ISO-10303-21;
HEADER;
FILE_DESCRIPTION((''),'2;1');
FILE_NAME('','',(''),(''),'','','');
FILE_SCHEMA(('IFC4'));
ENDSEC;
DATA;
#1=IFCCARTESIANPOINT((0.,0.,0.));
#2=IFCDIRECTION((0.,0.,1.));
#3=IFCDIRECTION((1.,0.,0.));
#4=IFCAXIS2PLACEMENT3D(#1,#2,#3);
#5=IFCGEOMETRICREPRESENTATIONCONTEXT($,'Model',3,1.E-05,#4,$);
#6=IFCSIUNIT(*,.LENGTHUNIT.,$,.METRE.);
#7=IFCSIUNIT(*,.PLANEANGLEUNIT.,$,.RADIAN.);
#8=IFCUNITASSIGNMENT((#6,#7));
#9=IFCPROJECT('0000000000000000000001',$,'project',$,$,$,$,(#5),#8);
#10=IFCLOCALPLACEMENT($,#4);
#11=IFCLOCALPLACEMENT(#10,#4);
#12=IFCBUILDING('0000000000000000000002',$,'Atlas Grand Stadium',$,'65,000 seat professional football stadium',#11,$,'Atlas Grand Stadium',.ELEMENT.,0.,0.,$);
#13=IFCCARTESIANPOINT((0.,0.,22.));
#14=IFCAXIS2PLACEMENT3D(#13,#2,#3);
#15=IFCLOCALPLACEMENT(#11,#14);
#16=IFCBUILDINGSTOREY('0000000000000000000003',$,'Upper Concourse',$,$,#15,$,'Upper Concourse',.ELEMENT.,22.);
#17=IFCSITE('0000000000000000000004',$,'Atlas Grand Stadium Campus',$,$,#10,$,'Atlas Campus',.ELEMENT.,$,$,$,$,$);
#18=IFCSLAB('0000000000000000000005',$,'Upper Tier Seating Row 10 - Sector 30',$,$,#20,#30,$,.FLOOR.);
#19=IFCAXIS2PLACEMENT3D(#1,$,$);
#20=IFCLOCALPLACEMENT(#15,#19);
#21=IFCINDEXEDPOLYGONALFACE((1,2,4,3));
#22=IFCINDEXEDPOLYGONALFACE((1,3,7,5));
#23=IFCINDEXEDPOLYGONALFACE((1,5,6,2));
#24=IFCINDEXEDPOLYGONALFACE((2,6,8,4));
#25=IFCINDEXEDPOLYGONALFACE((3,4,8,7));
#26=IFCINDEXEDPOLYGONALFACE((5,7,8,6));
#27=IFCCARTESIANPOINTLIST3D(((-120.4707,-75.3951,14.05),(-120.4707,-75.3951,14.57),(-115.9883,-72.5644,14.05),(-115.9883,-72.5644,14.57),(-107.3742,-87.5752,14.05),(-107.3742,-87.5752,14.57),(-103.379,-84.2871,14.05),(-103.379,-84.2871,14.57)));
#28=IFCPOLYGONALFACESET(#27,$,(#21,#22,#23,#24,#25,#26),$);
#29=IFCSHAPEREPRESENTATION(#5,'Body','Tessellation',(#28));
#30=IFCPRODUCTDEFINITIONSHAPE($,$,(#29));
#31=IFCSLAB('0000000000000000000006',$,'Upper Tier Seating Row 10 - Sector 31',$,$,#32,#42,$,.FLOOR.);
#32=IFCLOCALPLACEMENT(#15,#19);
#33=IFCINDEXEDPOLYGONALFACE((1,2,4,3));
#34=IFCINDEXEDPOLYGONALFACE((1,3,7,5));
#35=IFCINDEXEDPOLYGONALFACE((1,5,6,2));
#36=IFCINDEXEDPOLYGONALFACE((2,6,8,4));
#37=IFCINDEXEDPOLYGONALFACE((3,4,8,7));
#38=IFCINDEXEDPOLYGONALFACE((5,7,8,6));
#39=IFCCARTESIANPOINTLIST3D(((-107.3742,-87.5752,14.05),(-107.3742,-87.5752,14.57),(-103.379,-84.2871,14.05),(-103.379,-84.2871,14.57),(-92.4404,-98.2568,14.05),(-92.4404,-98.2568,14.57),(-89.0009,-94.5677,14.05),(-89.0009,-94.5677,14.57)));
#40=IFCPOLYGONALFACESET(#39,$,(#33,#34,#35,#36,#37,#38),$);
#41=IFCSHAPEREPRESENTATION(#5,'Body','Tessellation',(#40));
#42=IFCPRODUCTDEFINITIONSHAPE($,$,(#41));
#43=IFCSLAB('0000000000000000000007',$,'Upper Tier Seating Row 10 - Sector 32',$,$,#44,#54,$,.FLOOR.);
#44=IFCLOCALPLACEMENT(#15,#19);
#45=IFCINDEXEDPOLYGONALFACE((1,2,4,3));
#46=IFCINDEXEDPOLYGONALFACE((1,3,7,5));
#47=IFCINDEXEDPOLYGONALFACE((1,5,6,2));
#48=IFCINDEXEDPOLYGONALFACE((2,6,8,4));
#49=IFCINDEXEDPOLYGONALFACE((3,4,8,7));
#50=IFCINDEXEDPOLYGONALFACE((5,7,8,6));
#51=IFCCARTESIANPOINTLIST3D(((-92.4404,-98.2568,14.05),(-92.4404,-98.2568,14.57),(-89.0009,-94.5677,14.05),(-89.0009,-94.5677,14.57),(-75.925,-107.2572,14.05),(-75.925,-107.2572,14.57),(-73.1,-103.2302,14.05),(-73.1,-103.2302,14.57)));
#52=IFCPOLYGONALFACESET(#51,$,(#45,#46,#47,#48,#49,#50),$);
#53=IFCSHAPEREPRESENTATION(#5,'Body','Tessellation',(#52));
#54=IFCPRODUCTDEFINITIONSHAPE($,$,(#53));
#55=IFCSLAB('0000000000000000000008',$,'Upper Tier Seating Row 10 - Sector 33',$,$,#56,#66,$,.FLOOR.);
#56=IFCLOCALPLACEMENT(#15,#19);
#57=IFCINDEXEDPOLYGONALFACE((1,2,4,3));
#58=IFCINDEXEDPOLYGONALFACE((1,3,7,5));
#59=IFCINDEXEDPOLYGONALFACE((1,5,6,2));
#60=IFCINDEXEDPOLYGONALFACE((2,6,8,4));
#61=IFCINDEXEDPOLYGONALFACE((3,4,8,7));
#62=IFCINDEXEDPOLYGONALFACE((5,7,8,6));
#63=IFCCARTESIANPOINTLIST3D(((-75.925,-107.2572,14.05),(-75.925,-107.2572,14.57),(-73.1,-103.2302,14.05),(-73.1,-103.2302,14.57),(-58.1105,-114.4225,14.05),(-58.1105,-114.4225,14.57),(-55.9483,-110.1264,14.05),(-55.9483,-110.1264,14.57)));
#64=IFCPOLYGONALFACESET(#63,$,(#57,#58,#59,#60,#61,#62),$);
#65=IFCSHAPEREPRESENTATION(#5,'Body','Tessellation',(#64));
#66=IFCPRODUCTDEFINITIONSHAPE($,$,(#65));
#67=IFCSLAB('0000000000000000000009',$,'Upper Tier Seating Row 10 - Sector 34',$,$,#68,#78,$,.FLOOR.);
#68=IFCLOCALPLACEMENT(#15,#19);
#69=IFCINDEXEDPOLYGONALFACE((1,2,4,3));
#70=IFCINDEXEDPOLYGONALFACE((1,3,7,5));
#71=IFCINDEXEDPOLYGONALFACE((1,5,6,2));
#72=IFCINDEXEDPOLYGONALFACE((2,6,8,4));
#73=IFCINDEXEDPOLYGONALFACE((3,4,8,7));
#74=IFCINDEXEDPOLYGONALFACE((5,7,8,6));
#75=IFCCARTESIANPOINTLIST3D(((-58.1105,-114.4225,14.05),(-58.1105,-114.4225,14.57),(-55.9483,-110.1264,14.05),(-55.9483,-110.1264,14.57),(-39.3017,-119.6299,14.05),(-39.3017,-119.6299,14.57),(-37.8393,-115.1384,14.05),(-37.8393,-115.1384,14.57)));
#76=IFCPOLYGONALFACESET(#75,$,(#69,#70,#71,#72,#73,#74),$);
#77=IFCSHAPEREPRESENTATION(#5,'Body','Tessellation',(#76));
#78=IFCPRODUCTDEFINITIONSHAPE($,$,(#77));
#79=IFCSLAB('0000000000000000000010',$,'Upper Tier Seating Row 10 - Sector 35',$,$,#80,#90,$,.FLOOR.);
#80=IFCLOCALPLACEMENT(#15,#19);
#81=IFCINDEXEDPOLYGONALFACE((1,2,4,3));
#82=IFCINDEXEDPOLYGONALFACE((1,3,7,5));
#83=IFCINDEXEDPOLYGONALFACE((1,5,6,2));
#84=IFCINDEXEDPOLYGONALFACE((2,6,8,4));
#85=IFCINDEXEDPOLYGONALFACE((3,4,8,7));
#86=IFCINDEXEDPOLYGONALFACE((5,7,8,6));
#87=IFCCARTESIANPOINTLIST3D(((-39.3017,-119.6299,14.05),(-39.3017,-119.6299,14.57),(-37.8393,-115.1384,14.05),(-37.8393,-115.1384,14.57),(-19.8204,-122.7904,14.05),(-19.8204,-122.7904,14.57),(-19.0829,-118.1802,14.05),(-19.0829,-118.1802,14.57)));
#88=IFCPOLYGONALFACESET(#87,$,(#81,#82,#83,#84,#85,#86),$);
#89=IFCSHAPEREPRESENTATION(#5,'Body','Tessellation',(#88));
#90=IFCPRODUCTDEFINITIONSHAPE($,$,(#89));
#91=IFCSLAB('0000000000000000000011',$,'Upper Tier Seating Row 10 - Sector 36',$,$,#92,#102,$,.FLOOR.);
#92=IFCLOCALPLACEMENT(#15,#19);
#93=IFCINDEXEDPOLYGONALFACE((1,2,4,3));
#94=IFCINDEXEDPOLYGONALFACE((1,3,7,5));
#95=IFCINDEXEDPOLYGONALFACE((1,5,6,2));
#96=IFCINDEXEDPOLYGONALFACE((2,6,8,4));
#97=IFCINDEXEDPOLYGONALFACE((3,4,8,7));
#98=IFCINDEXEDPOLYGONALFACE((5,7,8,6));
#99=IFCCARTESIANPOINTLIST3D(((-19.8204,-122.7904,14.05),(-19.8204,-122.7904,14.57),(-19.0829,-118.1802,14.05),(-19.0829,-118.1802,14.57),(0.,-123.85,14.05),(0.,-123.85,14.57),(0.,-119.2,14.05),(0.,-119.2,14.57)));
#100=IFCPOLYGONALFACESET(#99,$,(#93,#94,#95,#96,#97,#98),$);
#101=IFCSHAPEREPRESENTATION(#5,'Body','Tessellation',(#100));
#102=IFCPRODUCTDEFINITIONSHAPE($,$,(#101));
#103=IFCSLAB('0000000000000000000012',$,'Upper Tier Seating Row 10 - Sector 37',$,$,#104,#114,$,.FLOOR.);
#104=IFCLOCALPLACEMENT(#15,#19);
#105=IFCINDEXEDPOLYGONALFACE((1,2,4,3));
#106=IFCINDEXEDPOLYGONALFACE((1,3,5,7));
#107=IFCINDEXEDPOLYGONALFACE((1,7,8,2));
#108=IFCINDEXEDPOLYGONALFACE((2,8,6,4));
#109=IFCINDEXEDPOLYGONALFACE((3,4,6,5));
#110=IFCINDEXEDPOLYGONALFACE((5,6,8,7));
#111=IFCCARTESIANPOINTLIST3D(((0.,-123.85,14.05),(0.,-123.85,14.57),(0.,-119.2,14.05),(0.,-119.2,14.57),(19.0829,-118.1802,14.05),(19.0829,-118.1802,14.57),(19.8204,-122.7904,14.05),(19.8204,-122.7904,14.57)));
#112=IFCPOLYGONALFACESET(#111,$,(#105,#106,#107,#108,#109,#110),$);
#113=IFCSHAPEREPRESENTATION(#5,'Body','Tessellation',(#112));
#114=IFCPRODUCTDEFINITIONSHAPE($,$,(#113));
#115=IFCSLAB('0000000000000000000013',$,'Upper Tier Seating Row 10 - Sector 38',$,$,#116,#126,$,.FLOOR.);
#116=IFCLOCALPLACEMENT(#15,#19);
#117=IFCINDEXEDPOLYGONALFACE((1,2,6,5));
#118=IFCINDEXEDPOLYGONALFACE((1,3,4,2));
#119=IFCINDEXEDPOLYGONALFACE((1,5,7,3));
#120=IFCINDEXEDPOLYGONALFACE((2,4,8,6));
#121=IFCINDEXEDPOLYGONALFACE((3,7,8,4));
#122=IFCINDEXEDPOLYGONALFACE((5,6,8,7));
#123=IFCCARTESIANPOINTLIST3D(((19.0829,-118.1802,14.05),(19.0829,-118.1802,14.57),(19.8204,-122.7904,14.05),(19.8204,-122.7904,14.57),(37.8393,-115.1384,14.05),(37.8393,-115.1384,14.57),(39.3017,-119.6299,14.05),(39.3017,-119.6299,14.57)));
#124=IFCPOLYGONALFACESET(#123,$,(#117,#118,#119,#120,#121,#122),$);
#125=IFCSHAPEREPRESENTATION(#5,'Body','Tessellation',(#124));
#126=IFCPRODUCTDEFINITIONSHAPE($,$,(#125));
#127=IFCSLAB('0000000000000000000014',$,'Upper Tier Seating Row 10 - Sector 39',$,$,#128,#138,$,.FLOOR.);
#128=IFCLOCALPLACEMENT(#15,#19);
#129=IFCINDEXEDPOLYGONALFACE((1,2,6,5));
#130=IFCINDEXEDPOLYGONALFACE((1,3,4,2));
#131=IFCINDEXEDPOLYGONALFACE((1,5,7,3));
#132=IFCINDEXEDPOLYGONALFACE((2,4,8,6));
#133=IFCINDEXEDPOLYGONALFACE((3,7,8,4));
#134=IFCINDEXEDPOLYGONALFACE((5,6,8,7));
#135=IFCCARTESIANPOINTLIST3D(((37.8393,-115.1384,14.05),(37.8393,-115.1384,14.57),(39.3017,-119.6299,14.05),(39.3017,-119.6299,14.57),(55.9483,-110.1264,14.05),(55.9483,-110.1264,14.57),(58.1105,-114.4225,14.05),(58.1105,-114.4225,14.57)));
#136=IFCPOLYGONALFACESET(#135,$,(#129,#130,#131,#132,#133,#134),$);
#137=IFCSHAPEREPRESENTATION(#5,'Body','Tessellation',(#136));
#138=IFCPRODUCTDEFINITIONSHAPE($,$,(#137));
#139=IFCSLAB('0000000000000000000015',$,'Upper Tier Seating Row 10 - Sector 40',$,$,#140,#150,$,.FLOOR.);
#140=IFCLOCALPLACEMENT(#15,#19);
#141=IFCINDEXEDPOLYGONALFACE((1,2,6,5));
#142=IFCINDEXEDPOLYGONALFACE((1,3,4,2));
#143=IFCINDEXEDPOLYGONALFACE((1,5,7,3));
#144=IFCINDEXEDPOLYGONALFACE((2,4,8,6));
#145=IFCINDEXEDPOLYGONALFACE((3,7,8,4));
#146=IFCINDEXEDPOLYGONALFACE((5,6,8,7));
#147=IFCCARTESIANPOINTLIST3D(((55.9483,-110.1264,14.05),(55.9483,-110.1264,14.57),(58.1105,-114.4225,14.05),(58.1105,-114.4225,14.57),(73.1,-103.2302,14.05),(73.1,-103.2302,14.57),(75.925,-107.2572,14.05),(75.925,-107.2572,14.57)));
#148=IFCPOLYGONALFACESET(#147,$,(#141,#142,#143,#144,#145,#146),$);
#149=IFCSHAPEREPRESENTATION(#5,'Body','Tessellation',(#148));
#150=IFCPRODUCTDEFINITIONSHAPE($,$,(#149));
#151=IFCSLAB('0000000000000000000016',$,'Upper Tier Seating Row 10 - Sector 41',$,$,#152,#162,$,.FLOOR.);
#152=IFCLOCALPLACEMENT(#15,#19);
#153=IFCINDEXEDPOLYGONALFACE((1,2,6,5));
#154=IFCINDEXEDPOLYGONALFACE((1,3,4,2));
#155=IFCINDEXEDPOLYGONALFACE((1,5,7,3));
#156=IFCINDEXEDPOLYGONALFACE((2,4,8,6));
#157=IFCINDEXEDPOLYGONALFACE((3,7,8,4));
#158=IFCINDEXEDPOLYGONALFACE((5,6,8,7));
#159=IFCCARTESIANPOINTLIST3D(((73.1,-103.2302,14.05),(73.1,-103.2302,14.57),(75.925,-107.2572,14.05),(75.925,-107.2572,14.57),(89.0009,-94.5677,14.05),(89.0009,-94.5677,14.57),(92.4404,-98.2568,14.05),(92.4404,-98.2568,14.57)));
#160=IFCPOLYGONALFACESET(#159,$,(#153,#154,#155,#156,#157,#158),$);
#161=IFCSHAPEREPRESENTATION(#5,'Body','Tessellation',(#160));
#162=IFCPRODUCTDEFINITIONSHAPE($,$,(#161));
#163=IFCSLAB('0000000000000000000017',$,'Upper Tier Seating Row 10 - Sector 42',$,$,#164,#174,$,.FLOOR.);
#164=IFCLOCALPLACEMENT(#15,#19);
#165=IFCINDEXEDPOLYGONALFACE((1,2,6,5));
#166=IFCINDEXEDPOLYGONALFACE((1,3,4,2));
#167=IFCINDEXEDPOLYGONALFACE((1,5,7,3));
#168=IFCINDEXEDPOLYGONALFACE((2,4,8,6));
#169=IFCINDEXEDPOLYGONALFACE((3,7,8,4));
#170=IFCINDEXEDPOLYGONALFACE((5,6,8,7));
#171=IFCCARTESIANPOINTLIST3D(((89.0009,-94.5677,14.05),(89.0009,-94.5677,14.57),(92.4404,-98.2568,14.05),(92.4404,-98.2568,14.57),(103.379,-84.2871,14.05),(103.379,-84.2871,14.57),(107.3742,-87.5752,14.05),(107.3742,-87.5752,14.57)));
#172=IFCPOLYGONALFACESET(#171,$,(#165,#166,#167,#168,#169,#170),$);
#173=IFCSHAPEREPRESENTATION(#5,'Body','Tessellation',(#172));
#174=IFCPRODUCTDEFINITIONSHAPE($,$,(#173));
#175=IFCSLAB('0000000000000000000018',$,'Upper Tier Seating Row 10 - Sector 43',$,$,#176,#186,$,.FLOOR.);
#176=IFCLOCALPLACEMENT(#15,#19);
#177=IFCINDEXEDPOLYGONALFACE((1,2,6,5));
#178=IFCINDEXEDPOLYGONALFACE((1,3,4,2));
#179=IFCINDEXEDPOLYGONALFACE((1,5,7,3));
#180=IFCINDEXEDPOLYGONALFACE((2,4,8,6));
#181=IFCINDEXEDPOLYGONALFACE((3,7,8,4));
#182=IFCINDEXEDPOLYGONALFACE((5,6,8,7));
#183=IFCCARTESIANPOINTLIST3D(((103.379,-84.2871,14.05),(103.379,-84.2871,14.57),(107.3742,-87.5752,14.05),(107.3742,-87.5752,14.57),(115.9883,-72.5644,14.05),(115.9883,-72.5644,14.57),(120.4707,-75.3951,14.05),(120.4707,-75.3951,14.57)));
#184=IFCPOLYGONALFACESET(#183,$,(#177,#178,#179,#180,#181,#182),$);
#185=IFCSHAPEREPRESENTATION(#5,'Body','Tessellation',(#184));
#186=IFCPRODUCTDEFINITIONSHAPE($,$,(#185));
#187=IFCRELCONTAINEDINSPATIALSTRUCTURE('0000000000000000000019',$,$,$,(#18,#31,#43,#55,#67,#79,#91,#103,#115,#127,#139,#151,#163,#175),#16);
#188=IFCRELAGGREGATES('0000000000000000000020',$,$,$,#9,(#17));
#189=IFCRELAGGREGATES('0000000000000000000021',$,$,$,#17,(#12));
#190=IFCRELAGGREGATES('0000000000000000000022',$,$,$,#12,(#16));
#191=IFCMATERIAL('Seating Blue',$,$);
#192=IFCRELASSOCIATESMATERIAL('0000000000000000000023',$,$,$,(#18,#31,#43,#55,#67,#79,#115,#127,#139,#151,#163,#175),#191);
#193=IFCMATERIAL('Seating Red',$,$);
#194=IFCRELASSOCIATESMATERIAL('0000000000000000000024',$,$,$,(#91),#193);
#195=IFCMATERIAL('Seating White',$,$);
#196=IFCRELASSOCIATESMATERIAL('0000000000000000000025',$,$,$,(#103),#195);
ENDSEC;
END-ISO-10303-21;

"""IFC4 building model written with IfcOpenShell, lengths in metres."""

from ifc_helpers import new_model, si_unit, frame, origin_with_axes, place, context, project, spatial, polyline, outline, extrude, material, element, save


model = new_model("IFC4")

# Units and contexts
model_context = context("Model", 3, precision=1e-05, world=origin_with_axes())
ifc_project = project(units=[si_unit("LENGTHUNIT", "METRE"), si_unit("PLANEANGLEUNIT", "RADIAN")], contexts=[model_context])

# Site, building, storey
site_placement = place(None, origin_with_axes())
site = spatial("IfcSite", under=ifc_project, at=site_placement, Name="Atlas Grand Stadium Campus", LongName="Atlas Campus", CompositionType="ELEMENT")
building_placement = place(site_placement, origin_with_axes())
building = spatial("IfcBuilding", under=site, at=building_placement, Name="Atlas Grand Stadium", ObjectType="65,000 seat professional football stadium", LongName="Atlas Grand Stadium", CompositionType="ELEMENT", ElevationOfRefHeight=0.0, ElevationOfTerrain=0.0)
storey_placement = place(building_placement, frame((0.0, 0.0, 22.0), z_axis=(0.0, 0.0, 1.0), x_axis=(1.0, 0.0, 0.0)))
storey = spatial("IfcBuildingStorey", under=building, at=storey_placement, Name="Upper Concourse", LongName="Upper Concourse", CompositionType="ELEMENT", Elevation=22.0)

# Slabs
ifc_material_1 = material(Name="Seating Blue")
slab_1_placement = place(storey_placement, frame((0.0, 0.0, 14.05), z_axis=(0.0, 0.0, 1.0), x_axis=(1.0, 0.0, 0.0)))
element("IfcSlab", 1, at=slab_1_placement, inside=storey, material=ifc_material_1, Name="Upper Tier Seating Row 10 - Sector 30", PredefinedType="FLOOR", context=model_context, shape_type="SweptSolid", body=[
    extrude(outline(polyline([(-120.4707, -75.3951), (-107.3742, -87.5752), (-103.379, -84.2871), (-115.9883, -72.5644), (-120.4707, -75.3951)])), origin_with_axes(), (0.0, 0.0, 1.0), 0.52),
])
slab_2_placement = place(storey_placement, frame((0.0, 0.0, 14.05), z_axis=(0.0, 0.0, 1.0), x_axis=(1.0, 0.0, 0.0)))
element("IfcSlab", 2, at=slab_2_placement, inside=storey, material=ifc_material_1, Name="Upper Tier Seating Row 10 - Sector 31", PredefinedType="FLOOR", context=model_context, shape_type="SweptSolid", body=[
    extrude(outline(polyline([(-107.3742, -87.5752), (-92.4404, -98.2568), (-89.0009, -94.5677), (-103.379, -84.2871), (-107.3742, -87.5752)])), origin_with_axes(), (0.0, 0.0, 1.0), 0.52),
])
slab_3_placement = place(storey_placement, frame((0.0, 0.0, 14.05), z_axis=(0.0, 0.0, 1.0), x_axis=(1.0, 0.0, 0.0)))
element("IfcSlab", 3, at=slab_3_placement, inside=storey, material=ifc_material_1, Name="Upper Tier Seating Row 10 - Sector 32", PredefinedType="FLOOR", context=model_context, shape_type="SweptSolid", body=[
    extrude(outline(polyline([(-92.4404, -98.2568), (-75.925, -107.2572), (-73.1, -103.2302), (-89.0009, -94.5677), (-92.4404, -98.2568)])), origin_with_axes(), (0.0, 0.0, 1.0), 0.52),
])
slab_4_placement = place(storey_placement, frame((0.0, 0.0, 14.05), z_axis=(0.0, 0.0, 1.0), x_axis=(1.0, 0.0, 0.0)))
element("IfcSlab", 4, at=slab_4_placement, inside=storey, material=ifc_material_1, Name="Upper Tier Seating Row 10 - Sector 33", PredefinedType="FLOOR", context=model_context, shape_type="SweptSolid", body=[
    extrude(outline(polyline([(-75.925, -107.2572), (-58.1105, -114.4225), (-55.9483, -110.1264), (-73.1, -103.2302), (-75.925, -107.2572)])), origin_with_axes(), (0.0, 0.0, 1.0), 0.52),
])
slab_5_placement = place(storey_placement, frame((0.0, 0.0, 14.05), z_axis=(0.0, 0.0, 1.0), x_axis=(1.0, 0.0, 0.0)))
element("IfcSlab", 5, at=slab_5_placement, inside=storey, material=ifc_material_1, Name="Upper Tier Seating Row 10 - Sector 34", PredefinedType="FLOOR", context=model_context, shape_type="SweptSolid", body=[
    extrude(outline(polyline([(-58.1105, -114.4225), (-39.3017, -119.6299), (-37.8393, -115.1384), (-55.9483, -110.1264), (-58.1105, -114.4225)])), origin_with_axes(), (0.0, 0.0, 1.0), 0.52),
])
slab_6_placement = place(storey_placement, frame((0.0, 0.0, 14.05), z_axis=(0.0, 0.0, 1.0), x_axis=(1.0, 0.0, 0.0)))
element("IfcSlab", 6, at=slab_6_placement, inside=storey, material=ifc_material_1, Name="Upper Tier Seating Row 10 - Sector 35", PredefinedType="FLOOR", context=model_context, shape_type="SweptSolid", body=[
    extrude(outline(polyline([(-39.3017, -119.6299), (-19.8204, -122.7905), (-19.0829, -118.1802), (-37.8393, -115.1384), (-39.3017, -119.6299)])), origin_with_axes(), (0.0, 0.0, 1.0), 0.52),
])
ifc_material_2 = material(Name="Seating Red")
slab_7_placement = place(storey_placement, frame((0.0, 0.0, 14.05), z_axis=(0.0, 0.0, 1.0), x_axis=(1.0, 0.0, 0.0)))
element("IfcSlab", 7, at=slab_7_placement, inside=storey, material=ifc_material_2, Name="Upper Tier Seating Row 10 - Sector 36", PredefinedType="FLOOR", context=model_context, shape_type="SweptSolid", body=[
    extrude(outline(polyline([(-19.8204, -122.7905), (0.0, -123.85), (0.0, -119.2), (-19.0829, -118.1802), (-19.8204, -122.7905)])), origin_with_axes(), (0.0, 0.0, 1.0), 0.52),
])
ifc_material_3 = material(Name="Seating White")
slab_8_placement = place(storey_placement, frame((0.0, 0.0, 14.05), z_axis=(0.0, 0.0, 1.0), x_axis=(1.0, 0.0, 0.0)))
element("IfcSlab", 8, at=slab_8_placement, inside=storey, material=ifc_material_3, Name="Upper Tier Seating Row 10 - Sector 37", PredefinedType="FLOOR", context=model_context, shape_type="SweptSolid", body=[
    extrude(outline(polyline([(0.0, -123.85), (19.8204, -122.7905), (19.0829, -118.1802), (0.0, -119.2), (0.0, -123.85)])), origin_with_axes(), (0.0, 0.0, 1.0), 0.52),
])
slab_9_placement = place(storey_placement, frame((0.0, 0.0, 14.05), z_axis=(0.0, 0.0, 1.0), x_axis=(1.0, 0.0, 0.0)))
element("IfcSlab", 9, at=slab_9_placement, inside=storey, material=ifc_material_1, Name="Upper Tier Seating Row 10 - Sector 38", PredefinedType="FLOOR", context=model_context, shape_type="SweptSolid", body=[
    extrude(outline(polyline([(19.8204, -122.7905), (39.3017, -119.6299), (37.8393, -115.1384), (19.0829, -118.1802), (19.8204, -122.7905)])), origin_with_axes(), (0.0, 0.0, 1.0), 0.52),
])
slab_10_placement = place(storey_placement, frame((0.0, 0.0, 14.05), z_axis=(0.0, 0.0, 1.0), x_axis=(1.0, 0.0, 0.0)))
element("IfcSlab", 10, at=slab_10_placement, inside=storey, material=ifc_material_1, Name="Upper Tier Seating Row 10 - Sector 39", PredefinedType="FLOOR", context=model_context, shape_type="SweptSolid", body=[
    extrude(outline(polyline([(39.3017, -119.6299), (58.1105, -114.4225), (55.9483, -110.1264), (37.8393, -115.1384), (39.3017, -119.6299)])), origin_with_axes(), (0.0, 0.0, 1.0), 0.52),
])
slab_11_placement = place(storey_placement, frame((0.0, 0.0, 14.05), z_axis=(0.0, 0.0, 1.0), x_axis=(1.0, 0.0, 0.0)))
element("IfcSlab", 11, at=slab_11_placement, inside=storey, material=ifc_material_1, Name="Upper Tier Seating Row 10 - Sector 40", PredefinedType="FLOOR", context=model_context, shape_type="SweptSolid", body=[
    extrude(outline(polyline([(58.1105, -114.4225), (75.925, -107.2572), (73.1, -103.2302), (55.9483, -110.1264), (58.1105, -114.4225)])), origin_with_axes(), (0.0, 0.0, 1.0), 0.52),
])
slab_12_placement = place(storey_placement, frame((0.0, 0.0, 14.05), z_axis=(0.0, 0.0, 1.0), x_axis=(1.0, 0.0, 0.0)))
element("IfcSlab", 12, at=slab_12_placement, inside=storey, material=ifc_material_1, Name="Upper Tier Seating Row 10 - Sector 41", PredefinedType="FLOOR", context=model_context, shape_type="SweptSolid", body=[
    extrude(outline(polyline([(75.925, -107.2572), (92.4404, -98.2568), (89.0009, -94.5677), (73.1, -103.2302), (75.925, -107.2572)])), origin_with_axes(), (0.0, 0.0, 1.0), 0.52),
])
slab_13_placement = place(storey_placement, frame((0.0, 0.0, 14.05), z_axis=(0.0, 0.0, 1.0), x_axis=(1.0, 0.0, 0.0)))
element("IfcSlab", 13, at=slab_13_placement, inside=storey, material=ifc_material_1, Name="Upper Tier Seating Row 10 - Sector 42", PredefinedType="FLOOR", context=model_context, shape_type="SweptSolid", body=[
    extrude(outline(polyline([(92.4404, -98.2568), (107.3742, -87.5752), (103.379, -84.2871), (89.0009, -94.5677), (92.4404, -98.2568)])), origin_with_axes(), (0.0, 0.0, 1.0), 0.52),
])
slab_14_placement = place(storey_placement, frame((0.0, 0.0, 14.05), z_axis=(0.0, 0.0, 1.0), x_axis=(1.0, 0.0, 0.0)))
element("IfcSlab", 14, at=slab_14_placement, inside=storey, material=ifc_material_1, Name="Upper Tier Seating Row 10 - Sector 43", PredefinedType="FLOOR", context=model_context, shape_type="SweptSolid", body=[
    extrude(outline(polyline([(107.3742, -87.5752), (120.4707, -75.3951), (115.9883, -72.5644), (103.379, -84.2871), (107.3742, -87.5752)])), origin_with_axes(), (0.0, 0.0, 1.0), 0.52),
])

save(model, "model.ifc")
